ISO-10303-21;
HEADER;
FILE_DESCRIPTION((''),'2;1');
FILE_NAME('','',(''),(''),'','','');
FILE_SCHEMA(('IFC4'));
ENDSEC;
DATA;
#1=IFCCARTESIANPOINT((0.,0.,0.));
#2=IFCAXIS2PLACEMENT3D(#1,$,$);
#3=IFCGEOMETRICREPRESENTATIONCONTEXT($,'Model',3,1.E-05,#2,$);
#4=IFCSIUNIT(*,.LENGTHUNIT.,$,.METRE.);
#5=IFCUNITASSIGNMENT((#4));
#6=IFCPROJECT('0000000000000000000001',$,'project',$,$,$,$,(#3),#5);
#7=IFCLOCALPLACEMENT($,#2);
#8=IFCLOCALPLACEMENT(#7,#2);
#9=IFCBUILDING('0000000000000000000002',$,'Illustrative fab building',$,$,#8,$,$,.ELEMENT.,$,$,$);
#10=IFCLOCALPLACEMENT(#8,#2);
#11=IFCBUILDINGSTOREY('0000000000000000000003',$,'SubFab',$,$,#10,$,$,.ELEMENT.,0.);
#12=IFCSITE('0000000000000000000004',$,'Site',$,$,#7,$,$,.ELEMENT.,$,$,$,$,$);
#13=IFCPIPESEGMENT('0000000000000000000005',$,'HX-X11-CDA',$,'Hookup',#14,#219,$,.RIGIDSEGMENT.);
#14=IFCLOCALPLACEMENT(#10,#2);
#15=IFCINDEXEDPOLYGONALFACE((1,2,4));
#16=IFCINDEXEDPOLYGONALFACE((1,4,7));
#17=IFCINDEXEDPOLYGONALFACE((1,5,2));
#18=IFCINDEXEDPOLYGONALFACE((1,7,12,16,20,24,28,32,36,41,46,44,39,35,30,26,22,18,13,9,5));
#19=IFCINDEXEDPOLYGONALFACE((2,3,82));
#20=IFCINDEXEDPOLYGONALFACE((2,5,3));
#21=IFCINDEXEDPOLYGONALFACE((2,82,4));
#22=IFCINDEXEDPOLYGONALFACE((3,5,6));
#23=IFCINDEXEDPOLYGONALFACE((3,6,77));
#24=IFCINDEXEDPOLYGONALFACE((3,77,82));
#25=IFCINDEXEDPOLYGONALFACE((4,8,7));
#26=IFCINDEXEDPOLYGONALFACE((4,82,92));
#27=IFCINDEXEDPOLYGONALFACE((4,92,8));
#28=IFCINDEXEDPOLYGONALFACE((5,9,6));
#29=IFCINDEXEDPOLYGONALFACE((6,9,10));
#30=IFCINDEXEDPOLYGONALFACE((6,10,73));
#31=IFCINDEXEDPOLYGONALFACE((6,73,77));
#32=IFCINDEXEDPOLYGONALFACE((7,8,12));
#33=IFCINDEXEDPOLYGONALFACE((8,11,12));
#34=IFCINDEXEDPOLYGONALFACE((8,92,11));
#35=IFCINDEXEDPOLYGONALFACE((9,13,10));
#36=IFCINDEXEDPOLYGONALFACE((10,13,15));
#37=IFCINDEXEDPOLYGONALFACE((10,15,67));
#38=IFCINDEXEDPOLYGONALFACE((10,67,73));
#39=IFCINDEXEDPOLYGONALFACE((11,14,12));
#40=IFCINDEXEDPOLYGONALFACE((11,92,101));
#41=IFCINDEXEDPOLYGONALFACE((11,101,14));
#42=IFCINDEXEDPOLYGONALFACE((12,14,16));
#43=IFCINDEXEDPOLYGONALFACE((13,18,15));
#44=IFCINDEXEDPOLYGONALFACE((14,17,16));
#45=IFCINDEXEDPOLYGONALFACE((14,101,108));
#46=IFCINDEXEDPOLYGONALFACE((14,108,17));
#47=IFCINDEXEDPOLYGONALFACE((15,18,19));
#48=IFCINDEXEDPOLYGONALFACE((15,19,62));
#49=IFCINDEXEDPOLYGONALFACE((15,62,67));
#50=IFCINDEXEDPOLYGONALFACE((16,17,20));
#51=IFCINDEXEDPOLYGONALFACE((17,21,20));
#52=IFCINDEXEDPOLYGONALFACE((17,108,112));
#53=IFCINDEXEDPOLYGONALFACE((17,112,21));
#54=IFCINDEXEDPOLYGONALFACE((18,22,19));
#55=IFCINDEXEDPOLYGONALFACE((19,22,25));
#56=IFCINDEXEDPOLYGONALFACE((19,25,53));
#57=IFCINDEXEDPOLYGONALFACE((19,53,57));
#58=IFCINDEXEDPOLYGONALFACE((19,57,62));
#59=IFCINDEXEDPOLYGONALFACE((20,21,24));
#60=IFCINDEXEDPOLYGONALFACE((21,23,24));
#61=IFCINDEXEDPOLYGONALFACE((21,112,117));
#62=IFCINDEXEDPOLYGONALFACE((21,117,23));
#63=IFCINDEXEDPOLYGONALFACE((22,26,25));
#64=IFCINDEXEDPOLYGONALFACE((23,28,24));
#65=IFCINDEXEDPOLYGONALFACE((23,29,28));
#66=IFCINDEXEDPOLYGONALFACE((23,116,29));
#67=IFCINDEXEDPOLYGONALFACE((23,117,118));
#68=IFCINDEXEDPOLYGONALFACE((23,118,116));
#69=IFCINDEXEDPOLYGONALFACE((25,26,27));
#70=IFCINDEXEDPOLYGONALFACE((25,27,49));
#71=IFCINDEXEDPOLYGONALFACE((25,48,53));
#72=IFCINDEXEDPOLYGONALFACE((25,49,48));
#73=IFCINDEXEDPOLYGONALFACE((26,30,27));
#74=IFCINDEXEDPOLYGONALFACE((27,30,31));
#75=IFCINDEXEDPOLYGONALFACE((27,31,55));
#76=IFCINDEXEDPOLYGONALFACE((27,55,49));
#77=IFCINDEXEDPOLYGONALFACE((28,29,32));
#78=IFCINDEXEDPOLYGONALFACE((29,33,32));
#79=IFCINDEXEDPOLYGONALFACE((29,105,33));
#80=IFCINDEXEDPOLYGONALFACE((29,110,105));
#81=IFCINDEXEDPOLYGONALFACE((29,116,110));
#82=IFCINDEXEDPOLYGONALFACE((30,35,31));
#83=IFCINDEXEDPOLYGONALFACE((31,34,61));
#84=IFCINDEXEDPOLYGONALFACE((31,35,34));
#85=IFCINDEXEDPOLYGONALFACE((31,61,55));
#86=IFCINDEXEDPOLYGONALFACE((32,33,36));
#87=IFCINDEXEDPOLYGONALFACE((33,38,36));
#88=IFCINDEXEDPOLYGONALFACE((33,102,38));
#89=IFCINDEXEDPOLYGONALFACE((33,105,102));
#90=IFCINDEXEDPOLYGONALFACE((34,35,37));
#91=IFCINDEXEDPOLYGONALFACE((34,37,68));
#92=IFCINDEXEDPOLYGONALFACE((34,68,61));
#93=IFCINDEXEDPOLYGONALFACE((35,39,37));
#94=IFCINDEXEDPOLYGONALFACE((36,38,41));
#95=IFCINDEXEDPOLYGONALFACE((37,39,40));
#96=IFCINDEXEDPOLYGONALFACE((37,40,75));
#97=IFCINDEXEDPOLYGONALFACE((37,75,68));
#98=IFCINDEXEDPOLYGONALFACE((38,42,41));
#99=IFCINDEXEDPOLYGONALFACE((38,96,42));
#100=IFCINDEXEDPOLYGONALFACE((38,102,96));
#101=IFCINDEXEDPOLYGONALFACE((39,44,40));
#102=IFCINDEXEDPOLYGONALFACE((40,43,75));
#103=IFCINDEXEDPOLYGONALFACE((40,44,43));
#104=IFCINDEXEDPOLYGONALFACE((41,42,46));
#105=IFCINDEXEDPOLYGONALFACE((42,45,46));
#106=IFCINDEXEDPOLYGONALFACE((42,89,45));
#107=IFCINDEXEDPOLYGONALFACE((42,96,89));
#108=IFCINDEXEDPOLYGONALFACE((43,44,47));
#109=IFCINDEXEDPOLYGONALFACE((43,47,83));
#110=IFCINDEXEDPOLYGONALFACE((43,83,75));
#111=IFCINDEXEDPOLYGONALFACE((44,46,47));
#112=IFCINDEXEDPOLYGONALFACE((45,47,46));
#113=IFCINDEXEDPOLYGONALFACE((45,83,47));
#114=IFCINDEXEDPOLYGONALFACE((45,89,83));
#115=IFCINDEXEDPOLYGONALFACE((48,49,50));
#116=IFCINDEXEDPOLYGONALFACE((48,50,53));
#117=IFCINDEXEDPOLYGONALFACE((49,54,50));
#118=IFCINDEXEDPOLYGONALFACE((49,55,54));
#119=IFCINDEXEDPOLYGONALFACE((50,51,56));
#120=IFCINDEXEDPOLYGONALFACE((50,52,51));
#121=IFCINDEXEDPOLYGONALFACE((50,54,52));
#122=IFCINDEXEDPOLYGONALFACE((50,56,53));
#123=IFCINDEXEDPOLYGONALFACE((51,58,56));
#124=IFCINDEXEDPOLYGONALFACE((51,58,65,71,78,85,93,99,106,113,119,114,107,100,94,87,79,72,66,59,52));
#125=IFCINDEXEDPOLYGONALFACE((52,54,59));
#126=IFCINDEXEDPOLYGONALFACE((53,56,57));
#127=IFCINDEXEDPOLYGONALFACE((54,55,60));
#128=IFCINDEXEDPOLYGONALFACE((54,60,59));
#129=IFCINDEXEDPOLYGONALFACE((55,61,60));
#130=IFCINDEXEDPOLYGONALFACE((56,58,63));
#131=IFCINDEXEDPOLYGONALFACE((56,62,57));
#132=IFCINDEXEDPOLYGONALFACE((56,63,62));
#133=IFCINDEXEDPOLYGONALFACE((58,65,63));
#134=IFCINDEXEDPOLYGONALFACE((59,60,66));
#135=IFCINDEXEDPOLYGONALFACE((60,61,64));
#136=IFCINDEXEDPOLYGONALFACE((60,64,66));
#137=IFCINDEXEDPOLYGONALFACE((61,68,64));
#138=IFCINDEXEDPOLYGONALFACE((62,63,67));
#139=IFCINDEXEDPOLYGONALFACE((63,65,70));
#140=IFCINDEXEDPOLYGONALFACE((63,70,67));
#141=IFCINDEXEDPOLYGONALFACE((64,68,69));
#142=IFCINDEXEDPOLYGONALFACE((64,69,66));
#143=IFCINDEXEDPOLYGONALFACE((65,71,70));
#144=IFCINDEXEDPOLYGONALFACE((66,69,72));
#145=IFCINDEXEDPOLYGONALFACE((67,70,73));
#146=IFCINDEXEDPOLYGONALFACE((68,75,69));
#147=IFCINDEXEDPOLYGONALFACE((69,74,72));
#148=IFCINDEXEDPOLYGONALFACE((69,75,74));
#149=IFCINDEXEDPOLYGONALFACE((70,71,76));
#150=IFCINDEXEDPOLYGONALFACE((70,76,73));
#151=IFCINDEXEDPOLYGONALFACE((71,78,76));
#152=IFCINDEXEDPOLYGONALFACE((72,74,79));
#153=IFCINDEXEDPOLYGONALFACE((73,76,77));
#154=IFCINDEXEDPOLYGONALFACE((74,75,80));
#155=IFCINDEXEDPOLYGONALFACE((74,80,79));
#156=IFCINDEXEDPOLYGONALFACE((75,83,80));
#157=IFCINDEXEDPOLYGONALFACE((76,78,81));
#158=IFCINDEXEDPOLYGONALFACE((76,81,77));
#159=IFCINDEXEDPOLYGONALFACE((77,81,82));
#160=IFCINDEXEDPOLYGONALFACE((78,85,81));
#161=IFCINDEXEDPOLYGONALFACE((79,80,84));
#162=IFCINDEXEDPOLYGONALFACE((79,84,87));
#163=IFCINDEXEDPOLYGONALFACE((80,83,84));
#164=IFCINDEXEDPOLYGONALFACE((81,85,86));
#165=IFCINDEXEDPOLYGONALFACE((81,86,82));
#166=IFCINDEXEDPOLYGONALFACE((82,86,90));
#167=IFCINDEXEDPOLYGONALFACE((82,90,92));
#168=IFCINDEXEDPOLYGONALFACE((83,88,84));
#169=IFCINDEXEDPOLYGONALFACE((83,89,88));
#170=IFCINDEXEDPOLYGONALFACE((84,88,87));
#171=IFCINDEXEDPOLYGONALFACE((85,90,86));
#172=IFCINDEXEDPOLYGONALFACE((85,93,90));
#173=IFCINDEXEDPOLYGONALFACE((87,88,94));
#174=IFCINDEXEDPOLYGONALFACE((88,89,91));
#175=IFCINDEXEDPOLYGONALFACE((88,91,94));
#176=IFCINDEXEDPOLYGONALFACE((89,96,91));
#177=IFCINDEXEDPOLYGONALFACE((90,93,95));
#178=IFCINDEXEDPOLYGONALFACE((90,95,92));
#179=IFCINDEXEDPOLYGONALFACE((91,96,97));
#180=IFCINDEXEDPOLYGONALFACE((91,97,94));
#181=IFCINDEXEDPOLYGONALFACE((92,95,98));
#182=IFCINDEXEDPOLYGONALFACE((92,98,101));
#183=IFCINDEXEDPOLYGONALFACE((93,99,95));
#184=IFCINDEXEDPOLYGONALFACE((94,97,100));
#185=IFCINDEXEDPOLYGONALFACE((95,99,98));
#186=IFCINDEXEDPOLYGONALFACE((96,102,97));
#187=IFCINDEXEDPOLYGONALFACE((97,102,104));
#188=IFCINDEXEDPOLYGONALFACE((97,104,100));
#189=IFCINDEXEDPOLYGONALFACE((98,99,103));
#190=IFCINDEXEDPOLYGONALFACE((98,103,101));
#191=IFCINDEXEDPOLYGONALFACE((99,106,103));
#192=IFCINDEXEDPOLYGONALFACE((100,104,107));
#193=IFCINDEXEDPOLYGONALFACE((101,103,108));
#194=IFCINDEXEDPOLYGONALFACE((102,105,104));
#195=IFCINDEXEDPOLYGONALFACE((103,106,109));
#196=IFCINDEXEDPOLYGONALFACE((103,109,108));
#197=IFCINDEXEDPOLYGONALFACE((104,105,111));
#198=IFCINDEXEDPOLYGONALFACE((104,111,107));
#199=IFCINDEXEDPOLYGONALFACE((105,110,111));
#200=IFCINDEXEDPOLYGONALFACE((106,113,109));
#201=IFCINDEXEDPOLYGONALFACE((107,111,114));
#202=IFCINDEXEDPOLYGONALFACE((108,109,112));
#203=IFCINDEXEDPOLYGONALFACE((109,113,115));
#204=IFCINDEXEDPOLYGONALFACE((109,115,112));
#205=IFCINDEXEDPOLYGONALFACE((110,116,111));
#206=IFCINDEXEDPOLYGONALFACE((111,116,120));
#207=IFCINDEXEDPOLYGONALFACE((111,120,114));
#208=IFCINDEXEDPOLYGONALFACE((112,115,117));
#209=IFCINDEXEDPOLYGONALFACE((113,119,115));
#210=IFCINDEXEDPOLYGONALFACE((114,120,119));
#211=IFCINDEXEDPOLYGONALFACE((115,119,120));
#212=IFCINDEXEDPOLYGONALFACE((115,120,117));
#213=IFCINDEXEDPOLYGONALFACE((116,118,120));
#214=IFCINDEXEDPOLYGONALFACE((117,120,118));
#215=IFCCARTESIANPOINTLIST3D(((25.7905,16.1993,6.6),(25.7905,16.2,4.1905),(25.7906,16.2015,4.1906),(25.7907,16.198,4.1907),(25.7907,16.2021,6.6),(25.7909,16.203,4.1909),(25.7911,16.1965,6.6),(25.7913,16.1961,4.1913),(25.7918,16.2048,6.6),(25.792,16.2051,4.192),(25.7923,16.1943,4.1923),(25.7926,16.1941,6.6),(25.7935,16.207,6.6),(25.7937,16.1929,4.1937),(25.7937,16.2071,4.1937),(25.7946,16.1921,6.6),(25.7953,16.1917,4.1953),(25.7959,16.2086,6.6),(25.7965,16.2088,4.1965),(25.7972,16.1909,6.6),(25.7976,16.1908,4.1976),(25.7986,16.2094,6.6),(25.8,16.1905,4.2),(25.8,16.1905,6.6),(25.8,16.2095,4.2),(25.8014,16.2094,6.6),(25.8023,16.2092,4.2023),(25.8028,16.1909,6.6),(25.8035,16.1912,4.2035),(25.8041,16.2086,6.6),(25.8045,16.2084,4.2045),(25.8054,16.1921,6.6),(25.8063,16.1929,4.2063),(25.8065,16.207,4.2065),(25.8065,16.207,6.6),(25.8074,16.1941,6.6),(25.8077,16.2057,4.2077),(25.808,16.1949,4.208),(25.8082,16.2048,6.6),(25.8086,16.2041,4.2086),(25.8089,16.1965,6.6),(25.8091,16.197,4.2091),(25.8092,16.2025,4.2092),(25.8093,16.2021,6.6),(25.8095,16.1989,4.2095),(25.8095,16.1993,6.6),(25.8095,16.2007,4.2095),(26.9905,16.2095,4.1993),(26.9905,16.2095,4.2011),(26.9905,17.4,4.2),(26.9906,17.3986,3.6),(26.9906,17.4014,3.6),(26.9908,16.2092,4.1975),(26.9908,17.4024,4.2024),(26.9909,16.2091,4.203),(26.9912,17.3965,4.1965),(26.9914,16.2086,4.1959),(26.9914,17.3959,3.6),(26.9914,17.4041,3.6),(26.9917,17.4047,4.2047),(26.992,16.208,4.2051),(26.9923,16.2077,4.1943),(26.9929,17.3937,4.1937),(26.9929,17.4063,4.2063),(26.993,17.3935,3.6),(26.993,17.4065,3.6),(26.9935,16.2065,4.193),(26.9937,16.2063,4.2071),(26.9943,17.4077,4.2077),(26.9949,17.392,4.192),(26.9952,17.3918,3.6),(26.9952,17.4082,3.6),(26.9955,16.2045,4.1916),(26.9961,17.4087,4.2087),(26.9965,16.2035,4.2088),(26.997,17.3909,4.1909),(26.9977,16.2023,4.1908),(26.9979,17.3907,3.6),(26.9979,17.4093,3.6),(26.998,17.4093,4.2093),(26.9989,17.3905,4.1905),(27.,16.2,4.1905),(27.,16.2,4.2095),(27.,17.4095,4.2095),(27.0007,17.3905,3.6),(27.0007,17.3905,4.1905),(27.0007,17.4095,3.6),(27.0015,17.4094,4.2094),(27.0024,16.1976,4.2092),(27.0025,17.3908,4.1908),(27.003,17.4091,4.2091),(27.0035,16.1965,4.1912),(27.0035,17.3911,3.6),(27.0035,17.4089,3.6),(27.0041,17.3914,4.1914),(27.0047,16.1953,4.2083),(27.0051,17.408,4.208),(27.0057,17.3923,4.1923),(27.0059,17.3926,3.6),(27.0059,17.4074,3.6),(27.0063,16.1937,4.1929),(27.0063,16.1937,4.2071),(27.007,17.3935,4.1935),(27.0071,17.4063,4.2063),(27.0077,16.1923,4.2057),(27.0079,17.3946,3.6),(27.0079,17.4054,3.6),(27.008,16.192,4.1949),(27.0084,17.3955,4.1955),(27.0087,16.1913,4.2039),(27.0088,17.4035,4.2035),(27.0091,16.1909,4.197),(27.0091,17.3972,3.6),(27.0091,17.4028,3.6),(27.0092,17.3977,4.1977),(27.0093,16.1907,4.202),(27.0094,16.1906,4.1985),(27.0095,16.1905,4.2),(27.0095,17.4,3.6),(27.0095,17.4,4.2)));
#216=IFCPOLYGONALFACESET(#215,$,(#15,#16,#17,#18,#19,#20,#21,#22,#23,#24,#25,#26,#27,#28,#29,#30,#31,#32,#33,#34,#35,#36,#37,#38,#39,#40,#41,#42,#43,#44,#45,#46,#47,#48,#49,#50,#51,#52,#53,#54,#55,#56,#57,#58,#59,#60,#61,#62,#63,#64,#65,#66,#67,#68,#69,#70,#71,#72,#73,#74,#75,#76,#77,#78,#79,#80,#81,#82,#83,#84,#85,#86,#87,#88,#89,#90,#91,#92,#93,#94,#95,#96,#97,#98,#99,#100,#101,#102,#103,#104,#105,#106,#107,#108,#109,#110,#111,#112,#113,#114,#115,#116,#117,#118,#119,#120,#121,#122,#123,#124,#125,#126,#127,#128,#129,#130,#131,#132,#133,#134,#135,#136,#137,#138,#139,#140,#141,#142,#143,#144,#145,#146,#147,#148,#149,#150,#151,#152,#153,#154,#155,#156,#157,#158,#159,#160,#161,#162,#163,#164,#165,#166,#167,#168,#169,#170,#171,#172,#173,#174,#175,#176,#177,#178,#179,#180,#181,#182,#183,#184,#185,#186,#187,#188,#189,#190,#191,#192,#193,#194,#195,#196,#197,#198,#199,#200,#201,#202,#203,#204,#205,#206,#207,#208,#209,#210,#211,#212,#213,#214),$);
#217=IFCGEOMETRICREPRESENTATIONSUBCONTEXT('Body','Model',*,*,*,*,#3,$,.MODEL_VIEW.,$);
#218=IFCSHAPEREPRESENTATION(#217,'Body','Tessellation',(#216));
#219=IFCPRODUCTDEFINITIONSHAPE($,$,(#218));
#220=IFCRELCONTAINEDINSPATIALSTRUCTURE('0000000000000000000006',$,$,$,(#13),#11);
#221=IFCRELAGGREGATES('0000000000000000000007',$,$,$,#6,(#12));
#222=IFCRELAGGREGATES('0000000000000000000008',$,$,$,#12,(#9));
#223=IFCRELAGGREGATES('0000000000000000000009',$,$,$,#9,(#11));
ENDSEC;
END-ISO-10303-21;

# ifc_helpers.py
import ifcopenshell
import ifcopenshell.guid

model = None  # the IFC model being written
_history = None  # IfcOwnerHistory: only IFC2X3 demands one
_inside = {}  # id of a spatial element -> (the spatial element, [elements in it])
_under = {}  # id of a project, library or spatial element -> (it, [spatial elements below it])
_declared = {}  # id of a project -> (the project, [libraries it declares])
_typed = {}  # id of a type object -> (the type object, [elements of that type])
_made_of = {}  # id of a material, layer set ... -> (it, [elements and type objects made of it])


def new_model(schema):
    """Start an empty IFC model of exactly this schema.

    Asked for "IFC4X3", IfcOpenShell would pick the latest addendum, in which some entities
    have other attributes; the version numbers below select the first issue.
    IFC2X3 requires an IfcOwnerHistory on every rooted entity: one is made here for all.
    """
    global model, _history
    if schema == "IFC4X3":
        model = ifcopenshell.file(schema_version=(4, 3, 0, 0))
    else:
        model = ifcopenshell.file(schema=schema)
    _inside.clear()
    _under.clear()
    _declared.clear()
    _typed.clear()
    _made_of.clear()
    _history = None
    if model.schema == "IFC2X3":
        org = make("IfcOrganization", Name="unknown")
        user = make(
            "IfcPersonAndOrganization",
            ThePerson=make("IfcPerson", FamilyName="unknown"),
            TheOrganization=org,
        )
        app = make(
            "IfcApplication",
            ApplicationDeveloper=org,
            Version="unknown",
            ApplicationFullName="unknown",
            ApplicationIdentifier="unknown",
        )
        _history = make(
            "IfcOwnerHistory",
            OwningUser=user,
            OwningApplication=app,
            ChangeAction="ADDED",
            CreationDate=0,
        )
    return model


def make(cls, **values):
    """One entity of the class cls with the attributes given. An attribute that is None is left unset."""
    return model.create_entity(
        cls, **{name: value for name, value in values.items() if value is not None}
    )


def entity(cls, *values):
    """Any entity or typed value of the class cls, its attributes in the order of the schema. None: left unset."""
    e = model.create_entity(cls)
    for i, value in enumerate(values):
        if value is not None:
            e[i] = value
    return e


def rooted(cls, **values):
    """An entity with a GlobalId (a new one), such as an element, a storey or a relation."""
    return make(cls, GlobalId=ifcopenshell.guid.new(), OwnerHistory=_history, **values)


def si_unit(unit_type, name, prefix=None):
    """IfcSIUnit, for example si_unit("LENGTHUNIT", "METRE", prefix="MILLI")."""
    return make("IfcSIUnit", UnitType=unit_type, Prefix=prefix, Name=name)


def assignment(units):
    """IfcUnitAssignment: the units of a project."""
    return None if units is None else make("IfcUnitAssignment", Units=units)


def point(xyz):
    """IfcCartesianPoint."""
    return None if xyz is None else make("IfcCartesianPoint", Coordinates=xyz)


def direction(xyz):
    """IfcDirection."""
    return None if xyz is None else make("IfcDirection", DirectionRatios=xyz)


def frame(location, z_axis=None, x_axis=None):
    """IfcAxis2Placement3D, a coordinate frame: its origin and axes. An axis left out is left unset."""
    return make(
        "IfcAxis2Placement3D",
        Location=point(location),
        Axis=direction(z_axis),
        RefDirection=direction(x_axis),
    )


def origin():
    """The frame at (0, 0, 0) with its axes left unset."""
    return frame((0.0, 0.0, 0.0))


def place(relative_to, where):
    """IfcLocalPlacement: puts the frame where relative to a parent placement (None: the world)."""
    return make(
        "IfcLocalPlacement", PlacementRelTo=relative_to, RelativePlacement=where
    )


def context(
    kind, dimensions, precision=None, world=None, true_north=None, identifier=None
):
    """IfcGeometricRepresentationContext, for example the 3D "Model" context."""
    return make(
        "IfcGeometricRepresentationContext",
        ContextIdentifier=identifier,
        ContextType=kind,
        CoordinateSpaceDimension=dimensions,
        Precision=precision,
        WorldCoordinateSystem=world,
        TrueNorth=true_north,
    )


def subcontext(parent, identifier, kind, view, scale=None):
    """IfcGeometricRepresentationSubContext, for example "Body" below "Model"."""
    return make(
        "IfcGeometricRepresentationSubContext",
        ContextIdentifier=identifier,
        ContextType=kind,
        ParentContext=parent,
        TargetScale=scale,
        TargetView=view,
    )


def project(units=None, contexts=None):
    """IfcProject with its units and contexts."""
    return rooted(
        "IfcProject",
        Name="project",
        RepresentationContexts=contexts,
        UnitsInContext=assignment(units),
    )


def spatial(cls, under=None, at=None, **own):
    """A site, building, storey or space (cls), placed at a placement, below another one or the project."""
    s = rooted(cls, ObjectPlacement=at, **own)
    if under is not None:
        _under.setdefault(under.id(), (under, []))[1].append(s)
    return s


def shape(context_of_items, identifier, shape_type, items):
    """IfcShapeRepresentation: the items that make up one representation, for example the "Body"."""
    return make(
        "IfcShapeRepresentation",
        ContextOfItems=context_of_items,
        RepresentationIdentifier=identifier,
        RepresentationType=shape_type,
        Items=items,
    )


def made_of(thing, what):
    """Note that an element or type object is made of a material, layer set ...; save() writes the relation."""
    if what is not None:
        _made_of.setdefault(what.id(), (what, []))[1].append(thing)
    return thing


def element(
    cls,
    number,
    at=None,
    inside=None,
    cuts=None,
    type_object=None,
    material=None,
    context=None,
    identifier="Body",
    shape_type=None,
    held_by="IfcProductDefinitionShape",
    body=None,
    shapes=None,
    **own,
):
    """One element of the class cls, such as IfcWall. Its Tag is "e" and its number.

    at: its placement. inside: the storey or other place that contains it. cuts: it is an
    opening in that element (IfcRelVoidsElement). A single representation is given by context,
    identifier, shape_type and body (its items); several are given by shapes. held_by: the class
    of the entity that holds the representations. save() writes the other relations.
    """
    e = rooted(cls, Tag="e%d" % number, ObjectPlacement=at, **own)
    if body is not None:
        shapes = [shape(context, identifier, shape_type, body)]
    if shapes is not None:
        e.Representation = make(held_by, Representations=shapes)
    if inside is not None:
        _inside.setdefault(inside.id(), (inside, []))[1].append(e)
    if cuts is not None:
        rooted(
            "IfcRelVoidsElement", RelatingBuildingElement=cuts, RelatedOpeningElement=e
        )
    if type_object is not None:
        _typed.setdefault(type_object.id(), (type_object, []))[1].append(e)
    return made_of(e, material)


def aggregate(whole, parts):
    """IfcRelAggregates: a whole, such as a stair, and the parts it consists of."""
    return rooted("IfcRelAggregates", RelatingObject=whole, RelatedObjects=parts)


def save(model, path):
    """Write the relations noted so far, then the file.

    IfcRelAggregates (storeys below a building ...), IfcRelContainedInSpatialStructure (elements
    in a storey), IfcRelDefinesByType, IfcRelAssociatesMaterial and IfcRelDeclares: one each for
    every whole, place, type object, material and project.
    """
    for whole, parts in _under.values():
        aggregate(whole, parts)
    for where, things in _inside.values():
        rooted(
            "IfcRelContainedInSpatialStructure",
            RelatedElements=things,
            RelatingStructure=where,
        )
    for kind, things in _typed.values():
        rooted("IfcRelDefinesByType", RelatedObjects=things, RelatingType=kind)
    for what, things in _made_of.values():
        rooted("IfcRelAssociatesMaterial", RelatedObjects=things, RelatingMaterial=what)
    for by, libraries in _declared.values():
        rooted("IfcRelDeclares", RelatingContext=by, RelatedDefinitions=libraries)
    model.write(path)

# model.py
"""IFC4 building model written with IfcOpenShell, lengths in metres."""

from ifc_helpers import new_model, entity, si_unit, origin, place, context, subcontext, project, spatial, element, save


model = new_model("IFC4")

# Units and contexts
model_context = context("Model", 3, precision=1e-05, world=origin())
body_context = subcontext(model_context, "Body", "Model", "MODEL_VIEW")
ifc_project = project(units=[si_unit("LENGTHUNIT", "METRE")], contexts=[model_context])

# Site, building, storey
site_placement = place(None, origin())
site = spatial("IfcSite", under=ifc_project, at=site_placement, Name="Site", CompositionType="ELEMENT")
building_placement = place(site_placement, origin())
building = spatial("IfcBuilding", under=site, at=building_placement, Name="Illustrative fab building", CompositionType="ELEMENT")
storey_placement = place(building_placement, origin())
storey = spatial("IfcBuildingStorey", under=building, at=storey_placement, Name="SubFab", CompositionType="ELEMENT", Elevation=0.0)

# Pipe segment
pipe_segment_1_placement = place(storey_placement, origin())
element("IfcPipeSegment", 1, at=pipe_segment_1_placement, inside=storey, Name="HX-X11-CDA", ObjectType="Hookup", PredefinedType="RIGIDSEGMENT", context=body_context, shape_type="AdvancedSweptSolid", body=[
    entity("IfcSweptDiskSolid", entity("IfcPolyline", [entity("IfcCartesianPoint", [27.0, 17.4, 3.6]), entity("IfcCartesianPoint", [27.0, 17.4, 4.2]), entity("IfcCartesianPoint", [27.0, 16.2, 4.2]), entity("IfcCartesianPoint", [25.8, 16.2, 4.2]), entity("IfcCartesianPoint", [25.8, 16.2, 6.6])]), 0.0095),
])

save(model, "model.ifc")
